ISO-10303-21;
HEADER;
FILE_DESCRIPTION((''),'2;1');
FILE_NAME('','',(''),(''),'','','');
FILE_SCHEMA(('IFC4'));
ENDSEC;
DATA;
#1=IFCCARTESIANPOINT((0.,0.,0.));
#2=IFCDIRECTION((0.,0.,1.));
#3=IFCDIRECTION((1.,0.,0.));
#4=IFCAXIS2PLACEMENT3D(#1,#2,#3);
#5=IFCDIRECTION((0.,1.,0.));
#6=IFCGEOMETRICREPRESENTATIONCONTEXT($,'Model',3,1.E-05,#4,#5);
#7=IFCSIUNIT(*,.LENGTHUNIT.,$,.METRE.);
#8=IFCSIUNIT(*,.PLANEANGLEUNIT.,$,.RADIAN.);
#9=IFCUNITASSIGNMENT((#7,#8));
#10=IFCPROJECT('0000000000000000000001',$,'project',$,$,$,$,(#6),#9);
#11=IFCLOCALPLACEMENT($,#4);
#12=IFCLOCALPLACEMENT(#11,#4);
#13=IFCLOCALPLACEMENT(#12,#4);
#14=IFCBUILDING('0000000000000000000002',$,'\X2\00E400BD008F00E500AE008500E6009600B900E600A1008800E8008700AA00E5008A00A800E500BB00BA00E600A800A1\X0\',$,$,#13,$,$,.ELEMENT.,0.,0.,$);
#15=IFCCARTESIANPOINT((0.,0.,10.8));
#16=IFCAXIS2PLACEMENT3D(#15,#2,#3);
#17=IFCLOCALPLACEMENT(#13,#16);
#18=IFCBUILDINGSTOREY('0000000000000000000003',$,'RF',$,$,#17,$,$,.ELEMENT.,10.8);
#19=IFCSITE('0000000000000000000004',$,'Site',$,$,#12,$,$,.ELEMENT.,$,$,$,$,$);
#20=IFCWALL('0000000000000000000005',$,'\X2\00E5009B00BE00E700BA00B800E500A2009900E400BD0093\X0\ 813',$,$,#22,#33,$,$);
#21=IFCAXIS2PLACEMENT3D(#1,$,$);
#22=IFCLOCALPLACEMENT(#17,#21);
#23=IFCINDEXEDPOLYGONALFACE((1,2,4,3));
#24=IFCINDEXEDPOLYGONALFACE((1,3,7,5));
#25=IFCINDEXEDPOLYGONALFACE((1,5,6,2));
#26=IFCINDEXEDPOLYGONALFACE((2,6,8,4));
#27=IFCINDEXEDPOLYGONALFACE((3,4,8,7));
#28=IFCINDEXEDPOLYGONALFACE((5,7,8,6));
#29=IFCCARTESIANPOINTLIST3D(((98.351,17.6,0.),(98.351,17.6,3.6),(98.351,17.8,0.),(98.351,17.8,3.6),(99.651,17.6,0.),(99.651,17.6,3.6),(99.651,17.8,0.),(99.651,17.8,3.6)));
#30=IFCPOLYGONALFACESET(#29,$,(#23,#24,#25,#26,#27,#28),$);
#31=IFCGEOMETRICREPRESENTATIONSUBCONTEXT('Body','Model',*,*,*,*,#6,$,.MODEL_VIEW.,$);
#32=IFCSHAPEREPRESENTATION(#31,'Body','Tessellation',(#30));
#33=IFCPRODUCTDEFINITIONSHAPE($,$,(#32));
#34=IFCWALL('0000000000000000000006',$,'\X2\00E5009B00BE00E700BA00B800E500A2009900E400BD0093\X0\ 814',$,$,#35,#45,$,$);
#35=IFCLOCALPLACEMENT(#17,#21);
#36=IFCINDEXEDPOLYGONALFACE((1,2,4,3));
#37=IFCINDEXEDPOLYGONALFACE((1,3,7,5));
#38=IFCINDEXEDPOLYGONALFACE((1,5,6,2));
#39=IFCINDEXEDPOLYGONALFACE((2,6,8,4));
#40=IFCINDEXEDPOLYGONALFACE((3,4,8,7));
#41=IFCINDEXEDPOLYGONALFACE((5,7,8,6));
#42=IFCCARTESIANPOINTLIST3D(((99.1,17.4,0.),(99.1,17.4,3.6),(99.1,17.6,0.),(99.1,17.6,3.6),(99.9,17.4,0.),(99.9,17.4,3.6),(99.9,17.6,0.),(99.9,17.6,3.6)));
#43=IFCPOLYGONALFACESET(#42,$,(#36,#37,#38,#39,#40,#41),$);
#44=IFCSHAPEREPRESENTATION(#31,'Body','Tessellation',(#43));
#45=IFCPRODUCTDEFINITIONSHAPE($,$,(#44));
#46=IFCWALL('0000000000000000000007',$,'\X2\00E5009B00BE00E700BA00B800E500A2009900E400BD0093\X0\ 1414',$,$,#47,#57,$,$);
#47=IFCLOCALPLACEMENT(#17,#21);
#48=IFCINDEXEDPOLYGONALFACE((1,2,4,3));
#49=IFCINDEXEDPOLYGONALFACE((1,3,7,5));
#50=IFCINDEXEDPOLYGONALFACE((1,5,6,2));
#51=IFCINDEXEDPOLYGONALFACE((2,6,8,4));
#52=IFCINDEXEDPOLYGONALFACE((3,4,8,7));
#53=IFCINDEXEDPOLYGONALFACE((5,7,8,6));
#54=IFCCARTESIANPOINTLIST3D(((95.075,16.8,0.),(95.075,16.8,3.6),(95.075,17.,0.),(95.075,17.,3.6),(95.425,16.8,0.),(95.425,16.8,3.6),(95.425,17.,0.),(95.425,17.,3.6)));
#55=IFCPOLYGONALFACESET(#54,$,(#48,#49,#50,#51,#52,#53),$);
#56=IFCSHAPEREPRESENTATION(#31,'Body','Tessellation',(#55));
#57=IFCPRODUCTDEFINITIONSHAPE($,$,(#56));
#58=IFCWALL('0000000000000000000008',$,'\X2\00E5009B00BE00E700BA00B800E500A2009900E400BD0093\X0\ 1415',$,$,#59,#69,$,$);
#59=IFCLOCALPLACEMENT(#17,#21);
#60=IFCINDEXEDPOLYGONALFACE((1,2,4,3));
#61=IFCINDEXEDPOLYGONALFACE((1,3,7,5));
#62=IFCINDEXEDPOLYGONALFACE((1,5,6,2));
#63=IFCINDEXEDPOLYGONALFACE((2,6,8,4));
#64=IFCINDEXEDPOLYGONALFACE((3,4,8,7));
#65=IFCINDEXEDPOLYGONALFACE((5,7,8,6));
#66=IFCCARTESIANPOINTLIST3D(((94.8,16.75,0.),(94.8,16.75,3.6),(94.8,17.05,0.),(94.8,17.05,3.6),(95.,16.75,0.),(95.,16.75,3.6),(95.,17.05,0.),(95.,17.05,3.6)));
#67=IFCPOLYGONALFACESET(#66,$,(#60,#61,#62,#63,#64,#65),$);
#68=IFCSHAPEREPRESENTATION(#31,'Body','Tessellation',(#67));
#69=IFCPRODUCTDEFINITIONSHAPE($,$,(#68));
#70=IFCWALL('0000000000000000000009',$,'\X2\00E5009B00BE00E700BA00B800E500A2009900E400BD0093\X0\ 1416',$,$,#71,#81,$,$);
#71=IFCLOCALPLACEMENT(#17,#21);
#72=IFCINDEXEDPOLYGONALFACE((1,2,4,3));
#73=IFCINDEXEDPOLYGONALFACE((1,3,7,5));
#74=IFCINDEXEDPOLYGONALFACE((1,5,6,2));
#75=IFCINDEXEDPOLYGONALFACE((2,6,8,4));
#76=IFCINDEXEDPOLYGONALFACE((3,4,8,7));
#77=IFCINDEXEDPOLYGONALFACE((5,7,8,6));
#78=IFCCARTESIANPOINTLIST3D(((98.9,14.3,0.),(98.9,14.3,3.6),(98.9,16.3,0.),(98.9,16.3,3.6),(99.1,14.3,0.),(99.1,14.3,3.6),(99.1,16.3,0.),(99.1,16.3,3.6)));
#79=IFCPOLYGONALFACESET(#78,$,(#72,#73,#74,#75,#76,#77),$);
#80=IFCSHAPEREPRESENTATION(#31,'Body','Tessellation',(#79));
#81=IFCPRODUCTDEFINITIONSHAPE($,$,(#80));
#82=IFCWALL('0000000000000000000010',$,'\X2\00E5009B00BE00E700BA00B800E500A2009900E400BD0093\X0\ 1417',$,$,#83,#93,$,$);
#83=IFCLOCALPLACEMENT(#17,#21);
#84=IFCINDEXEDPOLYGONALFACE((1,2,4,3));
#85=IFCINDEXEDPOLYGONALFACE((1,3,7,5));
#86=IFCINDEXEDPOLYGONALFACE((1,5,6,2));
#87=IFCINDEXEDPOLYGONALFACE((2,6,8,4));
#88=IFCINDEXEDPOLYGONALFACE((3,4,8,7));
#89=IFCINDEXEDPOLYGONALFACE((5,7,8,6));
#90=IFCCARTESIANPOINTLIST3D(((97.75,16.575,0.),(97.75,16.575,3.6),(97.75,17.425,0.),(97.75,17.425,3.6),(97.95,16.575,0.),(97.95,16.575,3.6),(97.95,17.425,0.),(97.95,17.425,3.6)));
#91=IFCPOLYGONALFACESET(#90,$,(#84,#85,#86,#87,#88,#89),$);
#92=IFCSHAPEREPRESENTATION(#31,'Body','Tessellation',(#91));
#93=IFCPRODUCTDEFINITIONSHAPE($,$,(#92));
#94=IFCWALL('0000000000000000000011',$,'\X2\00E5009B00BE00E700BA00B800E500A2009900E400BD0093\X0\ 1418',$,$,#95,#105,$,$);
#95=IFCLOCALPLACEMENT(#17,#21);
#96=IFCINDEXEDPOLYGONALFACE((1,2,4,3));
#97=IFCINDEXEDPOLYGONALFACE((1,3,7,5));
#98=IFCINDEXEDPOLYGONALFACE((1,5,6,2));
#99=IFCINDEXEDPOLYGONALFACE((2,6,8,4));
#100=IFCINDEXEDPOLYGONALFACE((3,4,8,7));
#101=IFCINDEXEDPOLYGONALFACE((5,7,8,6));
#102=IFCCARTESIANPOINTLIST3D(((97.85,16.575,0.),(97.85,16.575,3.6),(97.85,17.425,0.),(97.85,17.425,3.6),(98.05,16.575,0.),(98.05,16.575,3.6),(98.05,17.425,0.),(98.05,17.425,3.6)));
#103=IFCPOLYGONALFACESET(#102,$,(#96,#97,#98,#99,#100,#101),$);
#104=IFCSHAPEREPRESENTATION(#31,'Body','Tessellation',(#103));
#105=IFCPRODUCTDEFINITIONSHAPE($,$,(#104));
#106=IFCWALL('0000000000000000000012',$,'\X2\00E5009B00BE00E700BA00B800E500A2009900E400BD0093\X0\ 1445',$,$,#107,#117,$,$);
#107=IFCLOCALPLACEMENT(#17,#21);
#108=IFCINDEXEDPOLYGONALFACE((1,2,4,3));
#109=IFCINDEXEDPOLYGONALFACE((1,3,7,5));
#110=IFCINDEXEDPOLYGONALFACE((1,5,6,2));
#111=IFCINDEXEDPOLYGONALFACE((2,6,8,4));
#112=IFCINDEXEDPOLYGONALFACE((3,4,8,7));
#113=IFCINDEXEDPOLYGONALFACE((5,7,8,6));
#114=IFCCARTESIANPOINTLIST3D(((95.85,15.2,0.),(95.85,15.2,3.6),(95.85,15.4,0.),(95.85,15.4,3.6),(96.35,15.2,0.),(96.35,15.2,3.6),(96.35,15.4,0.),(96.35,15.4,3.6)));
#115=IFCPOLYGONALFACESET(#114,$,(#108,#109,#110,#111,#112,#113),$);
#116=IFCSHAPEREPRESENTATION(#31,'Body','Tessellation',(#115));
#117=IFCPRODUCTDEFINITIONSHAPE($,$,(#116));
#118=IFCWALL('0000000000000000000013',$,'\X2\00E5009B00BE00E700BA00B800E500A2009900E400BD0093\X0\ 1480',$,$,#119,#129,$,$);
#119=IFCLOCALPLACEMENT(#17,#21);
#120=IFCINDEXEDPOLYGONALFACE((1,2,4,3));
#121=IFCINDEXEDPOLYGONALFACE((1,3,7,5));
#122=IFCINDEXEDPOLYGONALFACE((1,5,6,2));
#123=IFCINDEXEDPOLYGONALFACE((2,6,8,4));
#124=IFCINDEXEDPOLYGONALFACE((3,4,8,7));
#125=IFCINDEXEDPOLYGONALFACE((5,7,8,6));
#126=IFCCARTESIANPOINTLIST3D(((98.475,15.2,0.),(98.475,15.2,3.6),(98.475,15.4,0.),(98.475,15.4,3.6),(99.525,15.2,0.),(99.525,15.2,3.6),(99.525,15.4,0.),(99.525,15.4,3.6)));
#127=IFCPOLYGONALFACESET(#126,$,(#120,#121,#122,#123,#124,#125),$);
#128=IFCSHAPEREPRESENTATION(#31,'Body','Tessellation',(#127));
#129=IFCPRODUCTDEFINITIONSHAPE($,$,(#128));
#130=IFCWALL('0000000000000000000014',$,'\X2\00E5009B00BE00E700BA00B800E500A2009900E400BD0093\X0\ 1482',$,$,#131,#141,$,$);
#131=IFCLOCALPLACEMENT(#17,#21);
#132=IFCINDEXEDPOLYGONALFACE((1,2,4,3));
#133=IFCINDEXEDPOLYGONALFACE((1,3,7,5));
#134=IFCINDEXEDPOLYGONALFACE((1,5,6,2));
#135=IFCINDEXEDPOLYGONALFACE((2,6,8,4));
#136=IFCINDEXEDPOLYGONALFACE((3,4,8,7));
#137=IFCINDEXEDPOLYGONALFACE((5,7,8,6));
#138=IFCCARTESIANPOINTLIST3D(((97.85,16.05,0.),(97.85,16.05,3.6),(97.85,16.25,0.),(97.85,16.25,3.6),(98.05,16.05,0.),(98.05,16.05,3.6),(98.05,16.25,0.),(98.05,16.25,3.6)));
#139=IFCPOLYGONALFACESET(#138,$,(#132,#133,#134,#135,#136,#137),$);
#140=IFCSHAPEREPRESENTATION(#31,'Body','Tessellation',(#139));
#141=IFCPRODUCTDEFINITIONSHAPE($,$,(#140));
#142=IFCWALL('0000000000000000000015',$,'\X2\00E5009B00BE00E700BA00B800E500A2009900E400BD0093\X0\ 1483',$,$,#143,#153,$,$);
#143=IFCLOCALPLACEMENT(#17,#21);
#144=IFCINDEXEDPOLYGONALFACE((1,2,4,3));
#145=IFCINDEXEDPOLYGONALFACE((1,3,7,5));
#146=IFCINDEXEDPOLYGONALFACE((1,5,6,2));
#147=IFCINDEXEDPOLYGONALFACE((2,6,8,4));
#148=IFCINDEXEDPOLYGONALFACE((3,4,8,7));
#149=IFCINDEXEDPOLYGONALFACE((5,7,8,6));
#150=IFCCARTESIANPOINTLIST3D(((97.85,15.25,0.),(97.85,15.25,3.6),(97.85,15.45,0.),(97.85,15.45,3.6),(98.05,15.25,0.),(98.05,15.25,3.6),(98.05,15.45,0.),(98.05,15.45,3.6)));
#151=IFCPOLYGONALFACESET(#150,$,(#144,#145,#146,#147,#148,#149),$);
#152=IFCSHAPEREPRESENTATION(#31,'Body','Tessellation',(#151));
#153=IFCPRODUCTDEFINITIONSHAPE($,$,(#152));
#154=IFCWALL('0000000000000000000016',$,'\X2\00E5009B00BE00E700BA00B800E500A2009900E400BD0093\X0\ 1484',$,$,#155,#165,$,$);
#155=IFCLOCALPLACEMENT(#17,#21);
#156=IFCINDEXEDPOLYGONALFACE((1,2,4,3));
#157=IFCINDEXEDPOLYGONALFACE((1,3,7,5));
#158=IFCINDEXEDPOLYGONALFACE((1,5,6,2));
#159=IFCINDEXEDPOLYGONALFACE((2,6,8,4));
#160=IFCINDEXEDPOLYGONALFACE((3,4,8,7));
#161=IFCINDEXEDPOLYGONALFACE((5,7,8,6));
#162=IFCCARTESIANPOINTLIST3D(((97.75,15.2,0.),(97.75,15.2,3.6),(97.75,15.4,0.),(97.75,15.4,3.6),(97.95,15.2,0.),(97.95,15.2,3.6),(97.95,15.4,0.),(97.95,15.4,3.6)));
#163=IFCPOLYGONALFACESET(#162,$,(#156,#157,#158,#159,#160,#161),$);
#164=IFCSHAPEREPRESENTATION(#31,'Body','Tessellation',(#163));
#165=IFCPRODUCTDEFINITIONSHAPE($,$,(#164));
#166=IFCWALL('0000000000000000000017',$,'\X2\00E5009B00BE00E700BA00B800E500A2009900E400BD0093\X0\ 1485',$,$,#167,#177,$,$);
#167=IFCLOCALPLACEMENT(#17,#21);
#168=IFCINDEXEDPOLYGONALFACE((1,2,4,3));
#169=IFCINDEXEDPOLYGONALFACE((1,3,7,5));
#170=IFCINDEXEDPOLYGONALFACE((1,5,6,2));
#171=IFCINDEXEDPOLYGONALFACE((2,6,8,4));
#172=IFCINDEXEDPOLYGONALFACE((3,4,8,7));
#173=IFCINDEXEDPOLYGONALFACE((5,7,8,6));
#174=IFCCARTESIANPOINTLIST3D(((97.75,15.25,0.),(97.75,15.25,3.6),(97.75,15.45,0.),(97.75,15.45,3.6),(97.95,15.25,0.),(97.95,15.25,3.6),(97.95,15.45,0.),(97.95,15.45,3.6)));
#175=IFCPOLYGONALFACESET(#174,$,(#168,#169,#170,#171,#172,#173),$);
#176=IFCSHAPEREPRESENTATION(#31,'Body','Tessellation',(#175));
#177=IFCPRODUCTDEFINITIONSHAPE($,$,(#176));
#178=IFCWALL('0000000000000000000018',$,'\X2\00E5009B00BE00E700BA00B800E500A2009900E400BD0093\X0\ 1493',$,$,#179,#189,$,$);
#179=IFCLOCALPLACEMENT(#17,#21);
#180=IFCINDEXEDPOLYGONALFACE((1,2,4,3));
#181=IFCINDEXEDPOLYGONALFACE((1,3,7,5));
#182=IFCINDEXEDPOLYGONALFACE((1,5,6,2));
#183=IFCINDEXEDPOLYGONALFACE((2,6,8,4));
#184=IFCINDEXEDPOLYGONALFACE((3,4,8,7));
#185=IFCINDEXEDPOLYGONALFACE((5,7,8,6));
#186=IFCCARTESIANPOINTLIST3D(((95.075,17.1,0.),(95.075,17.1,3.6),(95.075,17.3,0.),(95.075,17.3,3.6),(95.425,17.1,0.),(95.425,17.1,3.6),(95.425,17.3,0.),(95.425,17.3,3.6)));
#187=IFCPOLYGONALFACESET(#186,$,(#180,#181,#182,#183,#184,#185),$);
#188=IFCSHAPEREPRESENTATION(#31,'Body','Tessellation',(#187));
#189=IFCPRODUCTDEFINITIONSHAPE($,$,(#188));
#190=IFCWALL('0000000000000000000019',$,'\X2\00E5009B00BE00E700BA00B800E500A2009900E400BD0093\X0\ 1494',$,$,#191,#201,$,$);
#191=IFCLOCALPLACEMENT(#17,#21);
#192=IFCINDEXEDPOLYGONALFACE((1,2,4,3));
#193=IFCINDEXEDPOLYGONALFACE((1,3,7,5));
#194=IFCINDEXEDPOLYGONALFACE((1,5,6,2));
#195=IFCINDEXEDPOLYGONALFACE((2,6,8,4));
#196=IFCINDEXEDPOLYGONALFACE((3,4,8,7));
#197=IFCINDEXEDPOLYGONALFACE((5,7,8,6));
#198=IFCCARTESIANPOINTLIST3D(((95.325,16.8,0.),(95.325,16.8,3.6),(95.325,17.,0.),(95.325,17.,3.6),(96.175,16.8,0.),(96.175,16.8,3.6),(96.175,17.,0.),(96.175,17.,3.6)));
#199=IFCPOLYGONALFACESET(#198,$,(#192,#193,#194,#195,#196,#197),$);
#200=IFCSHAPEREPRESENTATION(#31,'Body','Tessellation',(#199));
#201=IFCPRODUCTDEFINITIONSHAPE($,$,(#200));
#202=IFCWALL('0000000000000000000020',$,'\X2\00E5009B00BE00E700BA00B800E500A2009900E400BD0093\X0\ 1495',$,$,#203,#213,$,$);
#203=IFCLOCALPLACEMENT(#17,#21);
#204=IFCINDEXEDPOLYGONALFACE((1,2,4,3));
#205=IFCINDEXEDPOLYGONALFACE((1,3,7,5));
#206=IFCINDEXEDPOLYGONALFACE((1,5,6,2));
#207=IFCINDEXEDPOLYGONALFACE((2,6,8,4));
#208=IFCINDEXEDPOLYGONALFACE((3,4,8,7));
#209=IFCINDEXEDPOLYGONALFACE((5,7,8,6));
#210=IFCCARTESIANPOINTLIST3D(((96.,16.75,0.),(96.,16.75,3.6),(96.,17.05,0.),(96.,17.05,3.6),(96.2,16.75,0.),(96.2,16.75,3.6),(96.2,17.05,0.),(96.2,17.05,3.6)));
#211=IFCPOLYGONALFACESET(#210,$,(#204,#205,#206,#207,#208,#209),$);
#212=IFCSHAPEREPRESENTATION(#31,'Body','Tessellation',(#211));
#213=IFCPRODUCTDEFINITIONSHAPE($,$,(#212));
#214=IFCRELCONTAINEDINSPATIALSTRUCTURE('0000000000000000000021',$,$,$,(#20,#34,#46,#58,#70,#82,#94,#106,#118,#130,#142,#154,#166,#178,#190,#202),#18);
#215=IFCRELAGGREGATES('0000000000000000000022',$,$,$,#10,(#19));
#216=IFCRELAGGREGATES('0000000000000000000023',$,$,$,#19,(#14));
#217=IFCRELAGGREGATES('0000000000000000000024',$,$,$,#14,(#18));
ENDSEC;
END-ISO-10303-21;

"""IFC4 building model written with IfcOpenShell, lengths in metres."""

from ifc_helpers import new_model, si_unit, direction, frame, frame_2d, origin_with_axes, place, context, subcontext, project, spatial, rectangle, extrude, element, save


model = new_model("IFC4")

# Units and contexts
model_context = context("Model", 3, precision=1e-05, world=origin_with_axes(), true_north=direction((0.0, 1.0, 0.0)))
body_context = subcontext(model_context, "Body", "Model", "MODEL_VIEW")
ifc_project = project(units=[si_unit("LENGTHUNIT", "METRE"), si_unit("PLANEANGLEUNIT", "RADIAN")], contexts=[model_context])

# Site, building, storey
placement = place(None, origin_with_axes())
site_placement = place(placement, origin_with_axes())
site = spatial("IfcSite", under=ifc_project, at=site_placement, Name="Site", CompositionType="ELEMENT")
building_placement = place(site_placement, origin_with_axes())
building = spatial("IfcBuilding", under=site, at=building_placement, Name="ä½\u008få®\u0085æ\u0096¹æ¡\u0088è\u0087ªå\u008a¨å»ºæ¨¡", CompositionType="ELEMENT", ElevationOfRefHeight=0.0, ElevationOfTerrain=0.0)
storey_placement = place(building_placement, frame((0.0, 0.0, 10.8), z_axis=(0.0, 0.0, 1.0), x_axis=(1.0, 0.0, 0.0)))
storey = spatial("IfcBuildingStorey", under=building, at=storey_placement, Name="RF", CompositionType="ELEMENT", Elevation=10.8)

# Walls
wall_1_placement = place(storey_placement, frame((99.001, 17.7, 0.0), z_axis=(0.0, 0.0, 1.0), x_axis=(1.0, 0.0, 0.0)))
element("IfcWall", 1, at=wall_1_placement, inside=storey, Name="å\u009b¾çº¸å¢\u0099ä½\u0093 813", context=body_context, shape_type="SweptSolid", body=[
    extrude(rectangle(XDim=1.3, YDim=0.2, at=frame_2d((0.0, 0.0), x_axis=(1.0, 0.0, 0.0))), frame((0.0, 0.0, 0.0), z_axis=(0.0, 0.0, 1.0)), (0.0, 0.0, 1.0), 3.6),
])
wall_2_placement = place(storey_placement, frame((99.5, 17.5, 0.0), z_axis=(0.0, 0.0, 1.0), x_axis=(1.0, 0.0, 0.0)))
element("IfcWall", 2, at=wall_2_placement, inside=storey, Name="å\u009b¾çº¸å¢\u0099ä½\u0093 814", context=body_context, shape_type="SweptSolid", body=[
    extrude(rectangle(XDim=0.8, YDim=0.2, at=frame_2d((0.0, 0.0), x_axis=(1.0, 0.0, 0.0))), frame((0.0, 0.0, 0.0), z_axis=(0.0, 0.0, 1.0)), (0.0, 0.0, 1.0), 3.6),
])
wall_3_placement = place(storey_placement, frame((95.25, 16.9, 0.0), z_axis=(0.0, 0.0, 1.0), x_axis=(-1.0, 0.0, 0.0)))
element("IfcWall", 3, at=wall_3_placement, inside=storey, Name="å\u009b¾çº¸å¢\u0099ä½\u0093 1414", context=body_context, shape_type="SweptSolid", body=[
    extrude(rectangle(XDim=0.35, YDim=0.2, at=frame_2d((0.0, 0.0), x_axis=(1.0, 0.0, 0.0))), frame((0.0, 0.0, 0.0), z_axis=(0.0, 0.0, 1.0)), (0.0, 0.0, 1.0), 3.6),
])
wall_4_placement = place(storey_placement, frame((94.9, 16.9, 0.0), z_axis=(0.0, 0.0, 1.0), x_axis=(0.0, 1.0, 0.0)))
element("IfcWall", 4, at=wall_4_placement, inside=storey, Name="å\u009b¾çº¸å¢\u0099ä½\u0093 1415", context=body_context, shape_type="SweptSolid", body=[
    extrude(rectangle(XDim=0.3, YDim=0.2, at=frame_2d((0.0, 0.0), x_axis=(1.0, 0.0, 0.0))), frame((0.0, 0.0, 0.0), z_axis=(0.0, 0.0, 1.0)), (0.0, 0.0, 1.0), 3.6),
])
wall_5_placement = place(storey_placement, frame((99.0, 15.3, 0.0), z_axis=(0.0, 0.0, 1.0), x_axis=(0.0, 1.0, 0.0)))
element("IfcWall", 5, at=wall_5_placement, inside=storey, Name="å\u009b¾çº¸å¢\u0099ä½\u0093 1416", context=body_context, shape_type="SweptSolid", body=[
    extrude(rectangle(XDim=2.0, YDim=0.2, at=frame_2d((0.0, 0.0), x_axis=(1.0, 0.0, 0.0))), frame((0.0, 0.0, 0.0), z_axis=(0.0, 0.0, 1.0)), (0.0, 0.0, 1.0), 3.6),
])
for number, where, z_axis, x_axis, name in (
    (6, (97.85, 17.0, 0.0), (0.0, 0.0, 1.0), (0.0, -1.0, 0.0), "å\u009b¾çº¸å¢\u0099ä½\u0093 1417"),
    (7, (97.95, 17.0, 0.0), (0.0, 0.0, 1.0), (0.0, -1.0, 0.0), "å\u009b¾çº¸å¢\u0099ä½\u0093 1418"),
):
    element("IfcWall", number, at=place(storey_placement, frame(where, z_axis=z_axis, x_axis=x_axis)), inside=storey, Name=name, context=body_context, shape_type="SweptSolid", body=[
        extrude(rectangle(XDim=0.85, YDim=0.2, at=frame_2d((0.0, 0.0), x_axis=(1.0, 0.0, 0.0))), frame((0.0, 0.0, 0.0), z_axis=(0.0, 0.0, 1.0)), (0.0, 0.0, 1.0), 3.6),
    ])
wall_6_placement = place(storey_placement, frame((96.1, 15.3, 0.0), z_axis=(0.0, 0.0, 1.0), x_axis=(-1.0, 0.0, 0.0)))
element("IfcWall", 8, at=wall_6_placement, inside=storey, Name="å\u009b¾çº¸å¢\u0099ä½\u0093 1445", context=body_context, shape_type="SweptSolid", body=[
    extrude(rectangle(XDim=0.5, YDim=0.2, at=frame_2d((0.0, 0.0), x_axis=(1.0, 0.0, 0.0))), frame((0.0, 0.0, 0.0), z_axis=(0.0, 0.0, 1.0)), (0.0, 0.0, 1.0), 3.6),
])
wall_7_placement = place(storey_placement, frame((99.0, 15.3, 0.0), z_axis=(0.0, 0.0, 1.0), x_axis=(-1.0, 0.0, 0.0)))
element("IfcWall", 9, at=wall_7_placement, inside=storey, Name="å\u009b¾çº¸å¢\u0099ä½\u0093 1480", context=body_context, shape_type="SweptSolid", body=[
    extrude(rectangle(XDim=1.05, YDim=0.2, at=frame_2d((0.0, 0.0), x_axis=(1.0, 0.0, 0.0))), frame((0.0, 0.0, 0.0), z_axis=(0.0, 0.0, 1.0)), (0.0, 0.0, 1.0), 3.6),
])
for number, where, z_axis, x_axis, name in (
    (10, (97.95, 16.15, 0.0), (0.0, 0.0, 1.0), (-1.0, 0.0, 0.0), "å\u009b¾çº¸å¢\u0099ä½\u0093 1482"),
    (11, (97.95, 15.35, 0.0), (0.0, 0.0, 1.0), (-1.0, 0.0, 0.0), "å\u009b¾çº¸å¢\u0099ä½\u0093 1483"),
    (12, (97.85, 15.3, 0.0), (0.0, 0.0, 1.0), (0.0, -1.0, 0.0), "å\u009b¾çº¸å¢\u0099ä½\u0093 1484"),
    (13, (97.85, 15.35, 0.0), (0.0, 0.0, 1.0), (0.0, -1.0, 0.0), "å\u009b¾çº¸å¢\u0099ä½\u0093 1485"),
):
    element("IfcWall", number, at=place(storey_placement, frame(where, z_axis=z_axis, x_axis=x_axis)), inside=storey, Name=name, context=body_context, shape_type="SweptSolid", body=[
        extrude(rectangle(XDim=0.2, YDim=0.2, at=frame_2d((0.0, 0.0), x_axis=(1.0, 0.0, 0.0))), frame((0.0, 0.0, 0.0), z_axis=(0.0, 0.0, 1.0)), (0.0, 0.0, 1.0), 3.6),
    ])
wall_8_placement = place(storey_placement, frame((95.25, 17.2, 0.0), z_axis=(0.0, 0.0, 1.0), x_axis=(-1.0, 0.0, 0.0)))
element("IfcWall", 14, at=wall_8_placement, inside=storey, Name="å\u009b¾çº¸å¢\u0099ä½\u0093 1493", context=body_context, shape_type="SweptSolid", body=[
    extrude(rectangle(XDim=0.35, YDim=0.2, at=frame_2d((0.0, 0.0), x_axis=(1.0, 0.0, 0.0))), frame((0.0, 0.0, 0.0), z_axis=(0.0, 0.0, 1.0)), (0.0, 0.0, 1.0), 3.6),
])
wall_9_placement = place(storey_placement, frame((95.75, 16.9, 0.0), z_axis=(0.0, 0.0, 1.0), x_axis=(-1.0, 0.0, 0.0)))
element("IfcWall", 15, at=wall_9_placement, inside=storey, Name="å\u009b¾çº¸å¢\u0099ä½\u0093 1494", context=body_context, shape_type="SweptSolid", body=[
    extrude(rectangle(XDim=0.85, YDim=0.2, at=frame_2d((0.0, 0.0), x_axis=(1.0, 0.0, 0.0))), frame((0.0, 0.0, 0.0), z_axis=(0.0, 0.0, 1.0)), (0.0, 0.0, 1.0), 3.6),
])
wall_10_placement = place(storey_placement, frame((96.1, 16.9, 0.0), z_axis=(0.0, 0.0, 1.0), x_axis=(0.0, 1.0, 0.0)))
element("IfcWall", 16, at=wall_10_placement, inside=storey, Name="å\u009b¾çº¸å¢\u0099ä½\u0093 1495", context=body_context, shape_type="SweptSolid", body=[
    extrude(rectangle(XDim=0.3, YDim=0.2, at=frame_2d((0.0, 0.0), x_axis=(1.0, 0.0, 0.0))), frame((0.0, 0.0, 0.0), z_axis=(0.0, 0.0, 1.0)), (0.0, 0.0, 1.0), 3.6),
])

save(model, "model.ifc")
